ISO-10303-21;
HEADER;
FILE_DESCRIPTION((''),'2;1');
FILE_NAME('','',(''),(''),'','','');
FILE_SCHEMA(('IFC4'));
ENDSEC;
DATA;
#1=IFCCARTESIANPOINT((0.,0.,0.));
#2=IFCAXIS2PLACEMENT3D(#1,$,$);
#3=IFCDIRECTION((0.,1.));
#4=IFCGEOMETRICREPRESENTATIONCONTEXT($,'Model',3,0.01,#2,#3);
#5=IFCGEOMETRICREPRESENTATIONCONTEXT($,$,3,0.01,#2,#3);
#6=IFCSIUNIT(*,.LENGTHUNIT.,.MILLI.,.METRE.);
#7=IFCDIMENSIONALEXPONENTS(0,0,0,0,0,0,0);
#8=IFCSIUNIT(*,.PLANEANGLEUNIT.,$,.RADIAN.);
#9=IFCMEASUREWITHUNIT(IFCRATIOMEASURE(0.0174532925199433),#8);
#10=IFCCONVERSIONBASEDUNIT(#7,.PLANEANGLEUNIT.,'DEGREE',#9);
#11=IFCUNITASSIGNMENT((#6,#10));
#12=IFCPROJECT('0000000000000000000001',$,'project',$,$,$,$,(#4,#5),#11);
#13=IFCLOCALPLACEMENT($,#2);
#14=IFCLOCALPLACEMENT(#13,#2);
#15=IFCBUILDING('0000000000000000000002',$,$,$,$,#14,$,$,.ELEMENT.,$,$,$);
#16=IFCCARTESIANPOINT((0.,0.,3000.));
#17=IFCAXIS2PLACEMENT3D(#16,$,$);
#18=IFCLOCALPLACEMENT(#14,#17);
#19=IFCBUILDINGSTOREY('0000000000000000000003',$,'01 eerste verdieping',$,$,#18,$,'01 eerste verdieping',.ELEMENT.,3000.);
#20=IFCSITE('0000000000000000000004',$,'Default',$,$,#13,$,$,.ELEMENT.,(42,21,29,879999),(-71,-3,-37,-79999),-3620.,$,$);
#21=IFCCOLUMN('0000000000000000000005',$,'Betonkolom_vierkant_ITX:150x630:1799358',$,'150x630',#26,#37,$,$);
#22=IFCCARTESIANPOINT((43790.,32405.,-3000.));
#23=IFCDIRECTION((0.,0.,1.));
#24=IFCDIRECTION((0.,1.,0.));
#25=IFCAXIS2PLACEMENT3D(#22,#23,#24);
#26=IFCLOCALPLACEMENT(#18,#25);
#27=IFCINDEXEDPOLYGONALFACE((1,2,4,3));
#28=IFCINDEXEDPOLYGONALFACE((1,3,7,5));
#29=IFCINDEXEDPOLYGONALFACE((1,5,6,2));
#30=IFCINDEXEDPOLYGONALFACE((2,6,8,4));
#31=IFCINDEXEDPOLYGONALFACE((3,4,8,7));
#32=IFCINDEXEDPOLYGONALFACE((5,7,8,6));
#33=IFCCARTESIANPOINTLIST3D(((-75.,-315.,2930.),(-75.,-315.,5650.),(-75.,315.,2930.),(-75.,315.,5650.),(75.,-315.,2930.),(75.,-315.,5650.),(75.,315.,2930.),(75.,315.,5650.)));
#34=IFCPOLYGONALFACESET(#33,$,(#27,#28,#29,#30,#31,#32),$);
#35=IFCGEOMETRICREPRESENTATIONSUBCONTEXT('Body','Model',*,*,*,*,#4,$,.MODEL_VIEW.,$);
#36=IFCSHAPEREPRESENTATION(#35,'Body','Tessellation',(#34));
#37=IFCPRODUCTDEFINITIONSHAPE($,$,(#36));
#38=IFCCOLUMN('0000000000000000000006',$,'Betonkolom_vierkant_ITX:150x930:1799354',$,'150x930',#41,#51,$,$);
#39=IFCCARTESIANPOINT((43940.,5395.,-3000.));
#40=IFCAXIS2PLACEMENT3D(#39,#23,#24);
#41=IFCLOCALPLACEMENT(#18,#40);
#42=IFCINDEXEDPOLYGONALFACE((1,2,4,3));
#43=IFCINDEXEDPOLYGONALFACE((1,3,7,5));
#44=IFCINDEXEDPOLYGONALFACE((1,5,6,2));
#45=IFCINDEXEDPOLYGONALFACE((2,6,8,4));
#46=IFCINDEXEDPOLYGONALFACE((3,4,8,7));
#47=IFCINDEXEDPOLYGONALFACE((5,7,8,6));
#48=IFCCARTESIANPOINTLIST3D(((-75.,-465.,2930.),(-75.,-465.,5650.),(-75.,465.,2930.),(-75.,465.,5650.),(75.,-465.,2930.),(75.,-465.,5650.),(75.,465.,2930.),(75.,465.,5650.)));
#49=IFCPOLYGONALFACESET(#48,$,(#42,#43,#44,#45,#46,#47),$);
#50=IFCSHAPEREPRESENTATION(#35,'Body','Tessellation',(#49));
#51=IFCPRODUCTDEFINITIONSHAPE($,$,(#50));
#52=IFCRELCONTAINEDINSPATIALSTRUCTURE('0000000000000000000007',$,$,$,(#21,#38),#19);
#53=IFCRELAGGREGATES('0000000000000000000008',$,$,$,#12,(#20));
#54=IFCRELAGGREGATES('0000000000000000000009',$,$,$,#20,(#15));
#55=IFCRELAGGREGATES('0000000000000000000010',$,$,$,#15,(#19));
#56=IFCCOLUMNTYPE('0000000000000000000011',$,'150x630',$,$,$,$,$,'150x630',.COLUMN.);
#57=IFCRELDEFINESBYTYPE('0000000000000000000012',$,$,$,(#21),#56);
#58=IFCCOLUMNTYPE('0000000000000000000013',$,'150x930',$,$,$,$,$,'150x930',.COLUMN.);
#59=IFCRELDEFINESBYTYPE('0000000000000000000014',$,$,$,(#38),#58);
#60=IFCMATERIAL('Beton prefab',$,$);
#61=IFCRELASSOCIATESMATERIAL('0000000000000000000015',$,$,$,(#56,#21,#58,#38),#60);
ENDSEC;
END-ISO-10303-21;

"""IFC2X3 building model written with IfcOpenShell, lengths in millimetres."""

from ifc_helpers import new_model, entity, si_unit, converted_unit, direction, frame, origin, origin_2d_with_axis, place, context, subcontext, project, spatial, rectangle, extrude, source, transform, mapped, material, type_object, type_shapes, element, save


model = new_model("IFC2X3")

# Units and contexts
model_context = context("Model", 3, precision=0.01, world=origin(), true_north=direction((0.0, 1.0)))
context_of_model = context(None, 3, precision=0.01, world=origin(), true_north=direction((0.0, 1.0)))
body_context = subcontext(model_context, "Body", "Model", "MODEL_VIEW")
ifc_project = project(units=[si_unit("LENGTHUNIT", "METRE", prefix="MILLI"), converted_unit("PLANEANGLEUNIT", "DEGREE", entity("IfcRatioMeasure", 0.0174532925199433), si_unit("PLANEANGLEUNIT", "RADIAN"), dimensions=[0, 0, 0, 0, 0, 0, 0])], contexts=[model_context, context_of_model])

# Site, building, storey
site_placement = place(None, origin())
site = spatial("IfcSite", under=ifc_project, at=site_placement, Name="Default", CompositionType="ELEMENT", RefLatitude=(42, 21, 29, 879999), RefLongitude=(-71, -3, -37, -79999), RefElevation=-3620.0)
building_placement = place(site_placement, origin())
building = spatial("IfcBuilding", under=site, at=building_placement, CompositionType="ELEMENT")
storey_placement = place(building_placement, frame((0.0, 0.0, 3000.0)))
storey = spatial("IfcBuildingStorey", under=building, at=storey_placement, Name="01 eerste verdieping", LongName="01 eerste verdieping", CompositionType="ELEMENT", Elevation=3000.0)

# Columns
ifc_material_1 = material(Name="Beton prefab")
column_type_1 = type_object("IfcColumnType", Name="150x630", ElementType="150x630", PredefinedType="COLUMN", material=ifc_material_1)
shared_shape_1 = source(origin(), body_context, "Body", "SweptSolid", [
    extrude(rectangle(XDim=630.0, YDim=150.0, at=origin_2d_with_axis()), frame((0.0, 0.0, 2930.0), z_axis=(0.0, 0.0, 1.0), x_axis=(0.0, -1.0, 0.0)), (0.0, 0.0, 1.0), 2720.0),
])
type_shapes(column_type_1, [shared_shape_1])
column_1_placement = place(storey_placement, frame((43790.0, 32405.0, -3000.0), z_axis=(0.0, 0.0, 1.0), x_axis=(0.0, 1.0, 0.0)))
element("IfcColumn", 1, at=column_1_placement, inside=storey, type_object=column_type_1, material=ifc_material_1, Name="Betonkolom_vierkant_ITX:150x630:1799358", ObjectType="150x630", context=body_context, shape_type="MappedRepresentation", body=[
    mapped(shared_shape_1, transform((0.0, 0.0, 0.0), scale=1.0)),
])
column_type_2 = type_object("IfcColumnType", Name="150x930", ElementType="150x930", PredefinedType="COLUMN", material=ifc_material_1)
shared_shape_2 = source(origin(), body_context, "Body", "SweptSolid", [
    extrude(rectangle(XDim=930.0, YDim=150.0, at=origin_2d_with_axis()), frame((0.0, 0.0, 2930.0), z_axis=(0.0, 0.0, 1.0), x_axis=(0.0, -1.0, 0.0)), (0.0, 0.0, 1.0), 2720.0),
])
type_shapes(column_type_2, [shared_shape_2])
column_2_placement = place(storey_placement, frame((43940.0, 5395.0, -3000.0), z_axis=(0.0, 0.0, 1.0), x_axis=(0.0, 1.0, 0.0)))
element("IfcColumn", 2, at=column_2_placement, inside=storey, type_object=column_type_2, material=ifc_material_1, Name="Betonkolom_vierkant_ITX:150x930:1799354", ObjectType="150x930", context=body_context, shape_type="MappedRepresentation", body=[
    mapped(shared_shape_2, transform((0.0, 0.0, 0.0), scale=1.0)),
])

save(model, "model.ifc")
